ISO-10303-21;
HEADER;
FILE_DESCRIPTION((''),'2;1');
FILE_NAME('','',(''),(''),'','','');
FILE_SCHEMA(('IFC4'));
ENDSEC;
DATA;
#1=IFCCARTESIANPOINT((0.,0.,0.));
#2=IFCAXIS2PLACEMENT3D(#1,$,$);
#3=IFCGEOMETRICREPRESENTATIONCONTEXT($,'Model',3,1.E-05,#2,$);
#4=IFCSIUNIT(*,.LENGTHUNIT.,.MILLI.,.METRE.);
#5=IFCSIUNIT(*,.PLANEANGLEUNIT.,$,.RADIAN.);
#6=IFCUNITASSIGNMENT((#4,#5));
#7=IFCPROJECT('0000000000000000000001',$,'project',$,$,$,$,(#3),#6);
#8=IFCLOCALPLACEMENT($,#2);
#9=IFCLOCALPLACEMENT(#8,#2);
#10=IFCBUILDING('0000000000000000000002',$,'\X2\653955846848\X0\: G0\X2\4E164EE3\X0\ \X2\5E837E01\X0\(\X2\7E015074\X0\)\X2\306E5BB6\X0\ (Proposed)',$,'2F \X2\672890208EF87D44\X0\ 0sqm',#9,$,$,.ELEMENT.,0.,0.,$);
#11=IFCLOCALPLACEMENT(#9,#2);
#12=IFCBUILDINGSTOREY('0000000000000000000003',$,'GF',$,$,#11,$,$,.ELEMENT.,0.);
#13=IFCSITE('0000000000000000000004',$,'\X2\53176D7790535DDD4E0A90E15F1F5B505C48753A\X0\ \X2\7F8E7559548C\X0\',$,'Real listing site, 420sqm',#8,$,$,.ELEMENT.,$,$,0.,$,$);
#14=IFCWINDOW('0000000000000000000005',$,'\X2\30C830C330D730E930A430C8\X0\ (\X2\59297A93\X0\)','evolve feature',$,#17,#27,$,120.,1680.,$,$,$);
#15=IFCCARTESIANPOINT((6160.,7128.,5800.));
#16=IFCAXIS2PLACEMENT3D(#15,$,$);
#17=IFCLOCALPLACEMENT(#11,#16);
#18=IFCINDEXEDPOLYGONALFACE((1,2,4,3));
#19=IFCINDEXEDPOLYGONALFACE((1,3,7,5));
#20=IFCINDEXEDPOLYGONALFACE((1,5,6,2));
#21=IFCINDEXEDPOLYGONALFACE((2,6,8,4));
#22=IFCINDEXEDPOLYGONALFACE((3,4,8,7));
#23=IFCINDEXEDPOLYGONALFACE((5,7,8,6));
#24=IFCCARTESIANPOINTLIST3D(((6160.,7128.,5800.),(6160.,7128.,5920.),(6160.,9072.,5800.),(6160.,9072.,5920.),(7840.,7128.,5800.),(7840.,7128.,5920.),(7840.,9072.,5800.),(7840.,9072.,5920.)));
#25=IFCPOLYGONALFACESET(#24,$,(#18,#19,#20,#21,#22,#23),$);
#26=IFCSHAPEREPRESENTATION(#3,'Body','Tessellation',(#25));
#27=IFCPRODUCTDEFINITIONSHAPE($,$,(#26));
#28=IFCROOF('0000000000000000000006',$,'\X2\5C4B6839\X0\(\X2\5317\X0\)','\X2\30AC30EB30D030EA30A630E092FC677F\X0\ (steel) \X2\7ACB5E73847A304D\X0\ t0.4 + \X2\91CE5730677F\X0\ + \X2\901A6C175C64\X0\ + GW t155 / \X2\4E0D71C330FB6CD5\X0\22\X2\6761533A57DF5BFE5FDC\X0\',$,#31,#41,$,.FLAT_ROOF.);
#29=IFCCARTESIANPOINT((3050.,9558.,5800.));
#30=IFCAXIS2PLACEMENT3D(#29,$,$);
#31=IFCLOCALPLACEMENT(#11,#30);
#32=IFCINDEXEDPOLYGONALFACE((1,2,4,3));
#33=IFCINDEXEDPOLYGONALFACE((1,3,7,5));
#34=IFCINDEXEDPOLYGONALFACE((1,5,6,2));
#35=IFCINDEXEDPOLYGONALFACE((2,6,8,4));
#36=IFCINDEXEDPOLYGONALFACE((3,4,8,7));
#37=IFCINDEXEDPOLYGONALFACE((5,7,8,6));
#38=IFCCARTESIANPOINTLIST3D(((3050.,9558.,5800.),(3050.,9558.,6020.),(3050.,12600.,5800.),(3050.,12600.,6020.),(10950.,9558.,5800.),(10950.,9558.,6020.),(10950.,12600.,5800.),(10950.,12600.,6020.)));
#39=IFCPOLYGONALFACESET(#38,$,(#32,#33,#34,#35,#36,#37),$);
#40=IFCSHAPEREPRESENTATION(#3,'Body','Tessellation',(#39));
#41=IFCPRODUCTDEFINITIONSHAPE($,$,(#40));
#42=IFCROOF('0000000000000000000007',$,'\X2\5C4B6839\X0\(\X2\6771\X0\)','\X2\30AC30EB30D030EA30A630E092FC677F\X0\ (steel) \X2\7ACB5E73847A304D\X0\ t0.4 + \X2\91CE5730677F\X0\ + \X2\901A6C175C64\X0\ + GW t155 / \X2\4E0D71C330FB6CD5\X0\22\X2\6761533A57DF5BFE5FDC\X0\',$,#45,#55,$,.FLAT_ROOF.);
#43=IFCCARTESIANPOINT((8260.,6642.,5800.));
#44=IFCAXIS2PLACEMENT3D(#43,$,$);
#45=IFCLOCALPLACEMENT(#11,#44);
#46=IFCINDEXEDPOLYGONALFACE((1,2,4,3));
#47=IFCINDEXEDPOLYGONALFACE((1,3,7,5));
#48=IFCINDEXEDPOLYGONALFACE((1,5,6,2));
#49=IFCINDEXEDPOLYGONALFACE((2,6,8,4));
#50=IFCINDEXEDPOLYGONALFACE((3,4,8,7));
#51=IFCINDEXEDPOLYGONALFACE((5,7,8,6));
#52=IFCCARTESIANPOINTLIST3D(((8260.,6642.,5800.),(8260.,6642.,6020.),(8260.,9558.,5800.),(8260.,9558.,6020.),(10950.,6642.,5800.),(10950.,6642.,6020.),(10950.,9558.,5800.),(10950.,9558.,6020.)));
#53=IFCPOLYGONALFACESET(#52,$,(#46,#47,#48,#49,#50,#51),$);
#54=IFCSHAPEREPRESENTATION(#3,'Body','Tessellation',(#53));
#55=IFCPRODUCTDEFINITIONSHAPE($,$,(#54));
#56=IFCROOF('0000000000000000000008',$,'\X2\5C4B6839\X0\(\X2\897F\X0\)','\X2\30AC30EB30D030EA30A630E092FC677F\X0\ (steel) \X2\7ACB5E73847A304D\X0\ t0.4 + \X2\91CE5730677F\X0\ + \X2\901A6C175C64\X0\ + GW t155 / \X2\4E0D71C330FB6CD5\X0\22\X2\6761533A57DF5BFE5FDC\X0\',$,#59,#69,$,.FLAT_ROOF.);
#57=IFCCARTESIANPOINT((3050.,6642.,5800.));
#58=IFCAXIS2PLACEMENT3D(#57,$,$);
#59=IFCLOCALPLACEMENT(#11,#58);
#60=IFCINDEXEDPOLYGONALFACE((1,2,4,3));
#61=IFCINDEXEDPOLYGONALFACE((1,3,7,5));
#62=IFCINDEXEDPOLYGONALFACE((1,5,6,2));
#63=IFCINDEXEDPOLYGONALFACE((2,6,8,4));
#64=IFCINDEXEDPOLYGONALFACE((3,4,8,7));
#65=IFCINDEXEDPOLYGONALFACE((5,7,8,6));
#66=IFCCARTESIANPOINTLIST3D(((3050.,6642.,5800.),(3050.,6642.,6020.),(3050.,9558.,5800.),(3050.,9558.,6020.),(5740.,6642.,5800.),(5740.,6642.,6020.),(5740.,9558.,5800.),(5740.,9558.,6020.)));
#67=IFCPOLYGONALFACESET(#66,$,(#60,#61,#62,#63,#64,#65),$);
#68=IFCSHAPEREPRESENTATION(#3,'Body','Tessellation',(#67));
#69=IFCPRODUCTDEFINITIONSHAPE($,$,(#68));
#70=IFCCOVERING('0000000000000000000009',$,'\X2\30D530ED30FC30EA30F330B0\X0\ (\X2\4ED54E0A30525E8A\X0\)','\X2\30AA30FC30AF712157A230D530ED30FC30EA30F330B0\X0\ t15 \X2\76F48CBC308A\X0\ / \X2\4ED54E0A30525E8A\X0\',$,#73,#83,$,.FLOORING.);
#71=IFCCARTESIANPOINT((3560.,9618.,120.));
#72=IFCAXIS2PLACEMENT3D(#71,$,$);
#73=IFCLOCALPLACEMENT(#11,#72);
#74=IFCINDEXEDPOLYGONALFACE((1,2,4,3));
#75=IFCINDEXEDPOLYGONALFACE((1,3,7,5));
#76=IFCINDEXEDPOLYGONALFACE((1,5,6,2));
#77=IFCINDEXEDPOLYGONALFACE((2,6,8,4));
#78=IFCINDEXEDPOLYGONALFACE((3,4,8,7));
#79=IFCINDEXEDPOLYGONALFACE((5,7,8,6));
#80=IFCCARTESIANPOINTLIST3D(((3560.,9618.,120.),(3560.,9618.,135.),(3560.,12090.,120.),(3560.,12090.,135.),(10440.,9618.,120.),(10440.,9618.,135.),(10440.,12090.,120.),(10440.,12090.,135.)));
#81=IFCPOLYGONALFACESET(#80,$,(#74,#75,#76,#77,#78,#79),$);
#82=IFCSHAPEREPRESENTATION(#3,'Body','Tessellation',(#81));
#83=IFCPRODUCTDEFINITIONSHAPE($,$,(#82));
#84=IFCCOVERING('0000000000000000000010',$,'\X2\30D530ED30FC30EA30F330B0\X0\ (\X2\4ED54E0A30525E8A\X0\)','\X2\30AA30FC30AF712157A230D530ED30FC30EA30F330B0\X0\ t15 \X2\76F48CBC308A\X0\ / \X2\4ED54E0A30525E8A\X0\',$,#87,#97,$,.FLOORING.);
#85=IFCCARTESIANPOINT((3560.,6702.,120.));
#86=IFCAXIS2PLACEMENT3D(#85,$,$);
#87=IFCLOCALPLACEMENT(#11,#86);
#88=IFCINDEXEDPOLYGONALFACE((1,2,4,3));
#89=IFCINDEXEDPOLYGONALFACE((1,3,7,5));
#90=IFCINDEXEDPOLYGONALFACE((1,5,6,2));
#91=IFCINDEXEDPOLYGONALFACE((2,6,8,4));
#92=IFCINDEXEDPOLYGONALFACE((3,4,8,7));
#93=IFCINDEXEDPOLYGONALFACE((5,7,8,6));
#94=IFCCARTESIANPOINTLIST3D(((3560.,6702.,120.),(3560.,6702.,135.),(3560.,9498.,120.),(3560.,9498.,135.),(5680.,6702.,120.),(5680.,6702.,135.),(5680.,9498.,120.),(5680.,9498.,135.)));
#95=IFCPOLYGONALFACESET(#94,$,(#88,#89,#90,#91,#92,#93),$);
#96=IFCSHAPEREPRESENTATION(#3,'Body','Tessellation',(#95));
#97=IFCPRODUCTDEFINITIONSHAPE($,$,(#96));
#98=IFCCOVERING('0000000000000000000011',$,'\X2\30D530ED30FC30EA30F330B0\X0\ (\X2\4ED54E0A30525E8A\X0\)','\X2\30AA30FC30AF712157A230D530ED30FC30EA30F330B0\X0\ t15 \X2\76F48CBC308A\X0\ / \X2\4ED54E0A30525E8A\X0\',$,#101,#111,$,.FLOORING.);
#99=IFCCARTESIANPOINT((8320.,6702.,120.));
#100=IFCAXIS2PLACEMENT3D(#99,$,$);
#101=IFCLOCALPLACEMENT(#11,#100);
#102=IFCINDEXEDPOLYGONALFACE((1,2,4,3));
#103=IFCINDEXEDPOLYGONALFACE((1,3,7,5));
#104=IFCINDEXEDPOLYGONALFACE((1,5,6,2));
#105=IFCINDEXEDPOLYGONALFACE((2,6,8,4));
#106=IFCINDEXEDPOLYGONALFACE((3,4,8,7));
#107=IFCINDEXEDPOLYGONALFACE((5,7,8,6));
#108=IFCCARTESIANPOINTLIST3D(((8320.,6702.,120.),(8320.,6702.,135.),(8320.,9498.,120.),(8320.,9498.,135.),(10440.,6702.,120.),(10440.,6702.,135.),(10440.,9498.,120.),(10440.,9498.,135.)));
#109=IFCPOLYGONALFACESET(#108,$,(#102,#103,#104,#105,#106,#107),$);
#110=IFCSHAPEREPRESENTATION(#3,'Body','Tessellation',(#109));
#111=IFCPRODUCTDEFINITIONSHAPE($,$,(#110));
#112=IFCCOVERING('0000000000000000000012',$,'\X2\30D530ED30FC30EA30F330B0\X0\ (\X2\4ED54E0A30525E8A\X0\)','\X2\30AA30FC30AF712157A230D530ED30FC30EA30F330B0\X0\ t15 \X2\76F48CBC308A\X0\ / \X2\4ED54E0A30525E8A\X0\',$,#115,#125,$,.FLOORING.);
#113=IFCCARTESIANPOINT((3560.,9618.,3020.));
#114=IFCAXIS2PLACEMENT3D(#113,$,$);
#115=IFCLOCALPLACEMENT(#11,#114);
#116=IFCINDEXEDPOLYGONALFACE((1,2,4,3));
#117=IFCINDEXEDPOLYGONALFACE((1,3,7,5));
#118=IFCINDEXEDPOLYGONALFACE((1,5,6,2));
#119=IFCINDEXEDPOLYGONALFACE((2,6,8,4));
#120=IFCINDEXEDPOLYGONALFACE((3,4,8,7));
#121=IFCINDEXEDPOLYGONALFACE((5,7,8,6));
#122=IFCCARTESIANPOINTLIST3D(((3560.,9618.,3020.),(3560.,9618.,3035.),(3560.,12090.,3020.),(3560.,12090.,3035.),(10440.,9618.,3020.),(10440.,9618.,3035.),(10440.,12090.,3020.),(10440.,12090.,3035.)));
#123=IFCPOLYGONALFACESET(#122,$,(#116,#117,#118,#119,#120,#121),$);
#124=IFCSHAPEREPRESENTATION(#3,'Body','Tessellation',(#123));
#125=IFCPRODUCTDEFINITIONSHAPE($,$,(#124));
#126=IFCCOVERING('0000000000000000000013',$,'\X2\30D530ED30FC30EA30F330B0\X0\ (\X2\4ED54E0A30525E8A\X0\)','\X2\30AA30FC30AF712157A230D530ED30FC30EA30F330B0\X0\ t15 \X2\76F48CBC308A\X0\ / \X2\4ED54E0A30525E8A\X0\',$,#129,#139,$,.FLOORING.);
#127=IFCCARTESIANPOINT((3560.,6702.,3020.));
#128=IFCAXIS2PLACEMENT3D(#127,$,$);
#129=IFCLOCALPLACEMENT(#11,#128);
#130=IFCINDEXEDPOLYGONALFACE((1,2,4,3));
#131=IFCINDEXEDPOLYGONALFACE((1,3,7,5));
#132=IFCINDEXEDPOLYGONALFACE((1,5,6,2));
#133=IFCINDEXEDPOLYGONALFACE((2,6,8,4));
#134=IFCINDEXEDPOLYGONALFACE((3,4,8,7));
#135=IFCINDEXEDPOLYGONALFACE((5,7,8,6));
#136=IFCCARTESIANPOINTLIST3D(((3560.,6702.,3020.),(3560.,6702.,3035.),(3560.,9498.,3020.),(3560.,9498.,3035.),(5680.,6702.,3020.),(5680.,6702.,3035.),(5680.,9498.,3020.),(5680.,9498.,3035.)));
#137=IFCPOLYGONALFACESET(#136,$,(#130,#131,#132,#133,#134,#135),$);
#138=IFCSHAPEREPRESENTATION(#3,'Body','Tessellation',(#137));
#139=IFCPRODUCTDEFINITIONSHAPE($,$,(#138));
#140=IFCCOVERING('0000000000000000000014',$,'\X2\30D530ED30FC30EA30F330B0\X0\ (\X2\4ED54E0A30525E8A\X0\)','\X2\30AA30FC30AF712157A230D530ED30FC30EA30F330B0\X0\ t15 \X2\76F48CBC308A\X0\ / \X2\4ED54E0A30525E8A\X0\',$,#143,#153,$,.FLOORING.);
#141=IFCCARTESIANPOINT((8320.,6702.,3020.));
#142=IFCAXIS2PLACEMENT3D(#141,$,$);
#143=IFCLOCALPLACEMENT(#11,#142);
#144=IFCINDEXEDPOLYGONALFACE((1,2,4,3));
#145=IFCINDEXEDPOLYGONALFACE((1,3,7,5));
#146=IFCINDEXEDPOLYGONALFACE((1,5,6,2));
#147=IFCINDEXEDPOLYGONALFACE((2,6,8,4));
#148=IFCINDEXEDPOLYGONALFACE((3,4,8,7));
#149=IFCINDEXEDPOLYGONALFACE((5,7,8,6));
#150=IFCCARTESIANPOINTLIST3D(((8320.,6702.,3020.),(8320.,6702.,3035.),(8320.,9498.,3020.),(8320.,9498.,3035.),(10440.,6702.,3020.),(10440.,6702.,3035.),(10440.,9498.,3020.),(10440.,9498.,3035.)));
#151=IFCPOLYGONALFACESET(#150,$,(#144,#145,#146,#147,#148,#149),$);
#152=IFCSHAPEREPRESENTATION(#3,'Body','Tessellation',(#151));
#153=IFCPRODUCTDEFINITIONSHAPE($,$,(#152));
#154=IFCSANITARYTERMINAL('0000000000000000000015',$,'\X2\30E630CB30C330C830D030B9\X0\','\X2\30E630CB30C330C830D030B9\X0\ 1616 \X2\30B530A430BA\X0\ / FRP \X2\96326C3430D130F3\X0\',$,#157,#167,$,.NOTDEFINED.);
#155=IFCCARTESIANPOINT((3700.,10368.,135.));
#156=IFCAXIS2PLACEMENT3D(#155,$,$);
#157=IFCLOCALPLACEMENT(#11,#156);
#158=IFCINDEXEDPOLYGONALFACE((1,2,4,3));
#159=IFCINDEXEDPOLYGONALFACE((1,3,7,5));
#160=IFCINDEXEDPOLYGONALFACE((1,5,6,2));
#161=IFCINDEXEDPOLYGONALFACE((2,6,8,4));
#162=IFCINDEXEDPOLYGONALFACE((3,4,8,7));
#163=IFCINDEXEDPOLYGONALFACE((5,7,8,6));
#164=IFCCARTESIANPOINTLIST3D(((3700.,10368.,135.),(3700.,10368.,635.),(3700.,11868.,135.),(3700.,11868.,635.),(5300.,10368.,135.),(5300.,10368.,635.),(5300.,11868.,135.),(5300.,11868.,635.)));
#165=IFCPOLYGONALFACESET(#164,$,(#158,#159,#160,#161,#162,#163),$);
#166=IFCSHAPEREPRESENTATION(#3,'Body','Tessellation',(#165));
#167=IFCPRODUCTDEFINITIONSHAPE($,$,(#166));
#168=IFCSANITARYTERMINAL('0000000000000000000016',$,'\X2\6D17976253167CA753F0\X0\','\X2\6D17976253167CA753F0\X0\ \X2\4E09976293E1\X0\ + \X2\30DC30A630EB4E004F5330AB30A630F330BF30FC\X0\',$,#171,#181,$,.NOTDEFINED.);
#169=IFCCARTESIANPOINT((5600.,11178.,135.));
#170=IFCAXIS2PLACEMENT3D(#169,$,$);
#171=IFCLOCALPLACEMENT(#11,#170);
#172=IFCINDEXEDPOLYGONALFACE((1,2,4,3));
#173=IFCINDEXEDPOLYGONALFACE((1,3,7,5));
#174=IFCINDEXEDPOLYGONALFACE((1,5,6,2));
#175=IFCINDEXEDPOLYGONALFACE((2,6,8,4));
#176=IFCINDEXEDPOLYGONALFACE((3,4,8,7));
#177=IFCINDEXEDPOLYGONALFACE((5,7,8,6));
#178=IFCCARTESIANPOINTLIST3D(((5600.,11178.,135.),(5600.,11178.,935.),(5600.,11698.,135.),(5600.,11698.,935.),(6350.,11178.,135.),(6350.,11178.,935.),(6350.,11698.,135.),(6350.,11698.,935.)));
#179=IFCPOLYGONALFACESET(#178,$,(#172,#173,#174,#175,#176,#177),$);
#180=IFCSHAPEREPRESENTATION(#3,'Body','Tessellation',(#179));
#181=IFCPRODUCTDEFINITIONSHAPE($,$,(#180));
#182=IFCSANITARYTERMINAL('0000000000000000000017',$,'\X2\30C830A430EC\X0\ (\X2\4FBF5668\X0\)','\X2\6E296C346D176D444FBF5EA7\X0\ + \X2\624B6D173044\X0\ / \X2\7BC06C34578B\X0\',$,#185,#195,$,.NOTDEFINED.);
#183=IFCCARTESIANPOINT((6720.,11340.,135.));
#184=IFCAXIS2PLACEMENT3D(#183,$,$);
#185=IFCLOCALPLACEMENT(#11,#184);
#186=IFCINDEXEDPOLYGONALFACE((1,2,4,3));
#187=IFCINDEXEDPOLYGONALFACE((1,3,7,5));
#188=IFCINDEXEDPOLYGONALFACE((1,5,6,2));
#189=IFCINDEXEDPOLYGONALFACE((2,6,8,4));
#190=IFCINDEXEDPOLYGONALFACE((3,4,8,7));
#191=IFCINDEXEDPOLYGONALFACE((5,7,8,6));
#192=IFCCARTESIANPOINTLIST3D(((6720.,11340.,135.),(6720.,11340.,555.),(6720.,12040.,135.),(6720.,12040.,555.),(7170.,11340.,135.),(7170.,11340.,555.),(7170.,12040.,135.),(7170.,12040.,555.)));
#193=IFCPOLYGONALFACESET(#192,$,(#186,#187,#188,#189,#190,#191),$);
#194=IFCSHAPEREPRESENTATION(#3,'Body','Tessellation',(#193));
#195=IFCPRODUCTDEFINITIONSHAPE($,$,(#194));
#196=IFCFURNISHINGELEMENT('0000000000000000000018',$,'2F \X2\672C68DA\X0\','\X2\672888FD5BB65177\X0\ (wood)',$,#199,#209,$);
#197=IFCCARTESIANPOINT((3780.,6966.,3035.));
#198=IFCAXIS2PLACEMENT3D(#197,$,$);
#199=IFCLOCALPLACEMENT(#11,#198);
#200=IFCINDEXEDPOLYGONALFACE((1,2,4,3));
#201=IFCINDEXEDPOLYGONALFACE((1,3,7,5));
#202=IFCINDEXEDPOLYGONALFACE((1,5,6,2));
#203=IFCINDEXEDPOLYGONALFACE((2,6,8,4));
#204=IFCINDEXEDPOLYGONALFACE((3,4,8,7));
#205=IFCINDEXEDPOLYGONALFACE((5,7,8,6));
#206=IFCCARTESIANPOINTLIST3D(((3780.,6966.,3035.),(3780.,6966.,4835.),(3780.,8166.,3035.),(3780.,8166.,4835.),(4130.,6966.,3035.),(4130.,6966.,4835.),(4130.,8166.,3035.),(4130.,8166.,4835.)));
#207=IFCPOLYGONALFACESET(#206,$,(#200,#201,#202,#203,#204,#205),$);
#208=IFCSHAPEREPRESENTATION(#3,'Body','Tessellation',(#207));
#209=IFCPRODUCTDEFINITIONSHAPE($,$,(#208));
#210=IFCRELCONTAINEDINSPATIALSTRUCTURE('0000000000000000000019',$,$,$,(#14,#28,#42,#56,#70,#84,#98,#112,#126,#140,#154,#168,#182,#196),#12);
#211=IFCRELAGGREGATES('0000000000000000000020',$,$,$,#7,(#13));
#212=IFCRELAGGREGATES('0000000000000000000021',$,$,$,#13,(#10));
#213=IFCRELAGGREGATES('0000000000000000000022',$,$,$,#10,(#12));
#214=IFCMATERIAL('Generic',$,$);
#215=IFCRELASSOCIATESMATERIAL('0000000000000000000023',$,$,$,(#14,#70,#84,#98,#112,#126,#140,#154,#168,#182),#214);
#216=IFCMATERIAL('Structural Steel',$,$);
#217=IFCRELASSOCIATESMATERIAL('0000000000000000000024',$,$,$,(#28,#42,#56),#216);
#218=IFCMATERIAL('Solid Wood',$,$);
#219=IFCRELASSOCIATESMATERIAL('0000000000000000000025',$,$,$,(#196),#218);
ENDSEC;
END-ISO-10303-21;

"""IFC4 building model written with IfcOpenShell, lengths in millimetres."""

from ifc_helpers import new_model, si_unit, frame, frame_2d, origin, place, context, project, spatial, rectangle, extrude, material, element, save


model = new_model("IFC4")

# Units and contexts
model_context = context("Model", 3, precision=1e-05, world=origin())
ifc_project = project(units=[si_unit("LENGTHUNIT", "METRE", prefix="MILLI"), si_unit("PLANEANGLEUNIT", "RADIAN")], contexts=[model_context])

# Site, building, storey
site_placement = place(None, origin())
site = spatial("IfcSite", under=ifc_project, at=site_placement, Name="北海道川上郡弟子屈町 美留和", ObjectType="Real listing site, 420sqm", CompositionType="ELEMENT", RefElevation=0.0)
building_placement = place(site_placement, origin())
building = spatial("IfcBuilding", under=site, at=building_placement, Name="改善案: G0世代 広縁(縁側)の家 (Proposed)", ObjectType="2F 木造軸組 0sqm", CompositionType="ELEMENT", ElevationOfRefHeight=0.0, ElevationOfTerrain=0.0)
storey_placement = place(building_placement, origin())
storey = spatial("IfcBuildingStorey", under=building, at=storey_placement, Name="GF", CompositionType="ELEMENT", Elevation=0.0)

# Shared definitions
ifc_material_1 = material(Name="Solid Wood")

# Window
ifc_material_2 = material(Name="Generic")
window_1_placement = place(storey_placement, frame((6160.0, 7128.0, 5800.0)))
element("IfcWindow", 1, at=window_1_placement, inside=storey, material=ifc_material_2, Name="トップライト (天窓)", Description="evolve feature", OverallHeight=120.0, OverallWidth=1680.0, context=model_context, shape_type="SweptSolid", body=[
    extrude(rectangle(XDim=1680.0, YDim=1944.0, at=frame_2d((840.0, 972.0))), frame((6160.0, 7128.0, 5800.0)), (0.0, 0.0, 1.0), 120.0),
])

# Roofs
ifc_material_3 = material(Name="Structural Steel")
roof_1_placement = place(storey_placement, frame((3050.0, 9558.0, 5800.0)))
element("IfcRoof", 2, at=roof_1_placement, inside=storey, material=ifc_material_3, Name="屋根(北)", Description="ガルバリウム鋼板 (steel) 立平葺き t0.4 + 野地板 + 通気層 + GW t155 / 不燃・法22条区域対応", PredefinedType="FLAT_ROOF", context=model_context, shape_type="SweptSolid", body=[
    extrude(rectangle(XDim=7900.0, YDim=3042.0, at=frame_2d((3950.0, 1521.0))), frame((3050.0, 9558.0, 5800.0)), (0.0, 0.0, 1.0), 220.0),
])
roof_2_placement = place(storey_placement, frame((8260.0, 6642.0, 5800.0)))
element("IfcRoof", 3, at=roof_2_placement, inside=storey, material=ifc_material_3, Name="屋根(東)", Description="ガルバリウム鋼板 (steel) 立平葺き t0.4 + 野地板 + 通気層 + GW t155 / 不燃・法22条区域対応", PredefinedType="FLAT_ROOF", context=model_context, shape_type="SweptSolid", body=[
    extrude(rectangle(XDim=2690.0, YDim=2916.0, at=frame_2d((1345.0, 1458.0))), frame((8260.0, 6642.0, 5800.0)), (0.0, 0.0, 1.0), 220.0),
])
roof_3_placement = place(storey_placement, frame((3050.0, 6642.0, 5800.0)))
element("IfcRoof", 4, at=roof_3_placement, inside=storey, material=ifc_material_3, Name="屋根(西)", Description="ガルバリウム鋼板 (steel) 立平葺き t0.4 + 野地板 + 通気層 + GW t155 / 不燃・法22条区域対応", PredefinedType="FLAT_ROOF", context=model_context, shape_type="SweptSolid", body=[
    extrude(rectangle(XDim=2690.0, YDim=2916.0, at=frame_2d((1345.0, 1458.0))), frame((3050.0, 6642.0, 5800.0)), (0.0, 0.0, 1.0), 220.0),
])

# Coverings
covering_1_placement = place(storey_placement, frame((3560.0, 9618.0, 120.0)))
element("IfcCovering", 5, at=covering_1_placement, inside=storey, material=ifc_material_2, Name="フローリング (仕上げ床)", Description="オーク無垢フローリング t15 直貼り / 仕上げ床", PredefinedType="FLOORING", context=model_context, shape_type="SweptSolid", body=[
    extrude(rectangle(XDim=6880.0, YDim=2472.0, at=frame_2d((3440.0, 1236.0))), frame((3560.0, 9618.0, 120.0)), (0.0, 0.0, 1.0), 15.0),
])
covering_2_placement = place(storey_placement, frame((3560.0, 6702.0, 120.0)))
element("IfcCovering", 6, at=covering_2_placement, inside=storey, material=ifc_material_2, Name="フローリング (仕上げ床)", Description="オーク無垢フローリング t15 直貼り / 仕上げ床", PredefinedType="FLOORING", context=model_context, shape_type="SweptSolid", body=[
    extrude(rectangle(XDim=2120.0, YDim=2796.0, at=frame_2d((1060.0, 1398.0))), frame((3560.0, 6702.0, 120.0)), (0.0, 0.0, 1.0), 15.0),
])
covering_3_placement = place(storey_placement, frame((8320.0, 6702.0, 120.0)))
element("IfcCovering", 7, at=covering_3_placement, inside=storey, material=ifc_material_2, Name="フローリング (仕上げ床)", Description="オーク無垢フローリング t15 直貼り / 仕上げ床", PredefinedType="FLOORING", context=model_context, shape_type="SweptSolid", body=[
    extrude(rectangle(XDim=2120.0, YDim=2796.0, at=frame_2d((1060.0, 1398.0))), frame((8320.0, 6702.0, 120.0)), (0.0, 0.0, 1.0), 15.0),
])
covering_4_placement = place(storey_placement, frame((3560.0, 9618.0, 3020.0)))
element("IfcCovering", 8, at=covering_4_placement, inside=storey, material=ifc_material_2, Name="フローリング (仕上げ床)", Description="オーク無垢フローリング t15 直貼り / 仕上げ床", PredefinedType="FLOORING", context=model_context, shape_type="SweptSolid", body=[
    extrude(rectangle(XDim=6880.0, YDim=2472.0, at=frame_2d((3440.0, 1236.0))), frame((3560.0, 9618.0, 3020.0)), (0.0, 0.0, 1.0), 15.0),
])
covering_5_placement = place(storey_placement, frame((3560.0, 6702.0, 3020.0)))
element("IfcCovering", 9, at=covering_5_placement, inside=storey, material=ifc_material_2, Name="フローリング (仕上げ床)", Description="オーク無垢フローリング t15 直貼り / 仕上げ床", PredefinedType="FLOORING", context=model_context, shape_type="SweptSolid", body=[
    extrude(rectangle(XDim=2120.0, YDim=2796.0, at=frame_2d((1060.0, 1398.0))), frame((3560.0, 6702.0, 3020.0)), (0.0, 0.0, 1.0), 15.0),
])
covering_6_placement = place(storey_placement, frame((8320.0, 6702.0, 3020.0)))
element("IfcCovering", 10, at=covering_6_placement, inside=storey, material=ifc_material_2, Name="フローリング (仕上げ床)", Description="オーク無垢フローリング t15 直貼り / 仕上げ床", PredefinedType="FLOORING", context=model_context, shape_type="SweptSolid", body=[
    extrude(rectangle(XDim=2120.0, YDim=2796.0, at=frame_2d((1060.0, 1398.0))), frame((8320.0, 6702.0, 3020.0)), (0.0, 0.0, 1.0), 15.0),
])

# Sanitary terminals
sanitary_terminal_1_placement = place(storey_placement, frame((3700.0, 10368.0, 135.0)))
element("IfcSanitaryTerminal", 11, at=sanitary_terminal_1_placement, inside=storey, material=ifc_material_2, Name="ユニットバス", Description="ユニットバス 1616 サイズ / FRP 防水パン", PredefinedType="NOTDEFINED", context=model_context, shape_type="SweptSolid", body=[
    extrude(rectangle(XDim=1600.0, YDim=1500.0, at=frame_2d((800.0, 750.0))), frame((3700.0, 10368.0, 135.0)), (0.0, 0.0, 1.0), 500.0),
])
sanitary_terminal_2_placement = place(storey_placement, frame((5600.0, 11178.0, 135.0)))
element("IfcSanitaryTerminal", 12, at=sanitary_terminal_2_placement, inside=storey, material=ifc_material_2, Name="洗面化粧台", Description="洗面化粧台 三面鏡 + ボウル一体カウンター", PredefinedType="NOTDEFINED", context=model_context, shape_type="SweptSolid", body=[
    extrude(rectangle(XDim=750.0, YDim=520.0, at=frame_2d((375.0, 260.0))), frame((5600.0, 11178.0, 135.0)), (0.0, 0.0, 1.0), 800.0),
])
sanitary_terminal_3_placement = place(storey_placement, frame((6720.0, 11340.0, 135.0)))
element("IfcSanitaryTerminal", 13, at=sanitary_terminal_3_placement, inside=storey, material=ifc_material_2, Name="トイレ (便器)", Description="温水洗浄便座 + 手洗い / 節水型", PredefinedType="NOTDEFINED", context=model_context, shape_type="SweptSolid", body=[
    extrude(rectangle(XDim=450.0, YDim=700.0, at=frame_2d((225.0, 350.0))), frame((6720.0, 11340.0, 135.0)), (0.0, 0.0, 1.0), 420.0),
])

# Furnishing element
furnishing_placement = place(storey_placement, frame((3780.0, 6966.0, 3035.0)))
element("IfcFurnishingElement", 14, at=furnishing_placement, inside=storey, material=ifc_material_1, Name="2F 本棚", Description="木製家具 (wood)", context=model_context, shape_type="SweptSolid", body=[
    extrude(rectangle(XDim=350.0, YDim=1200.0, at=frame_2d((175.0, 600.0))), frame((3780.0, 6966.0, 3035.0)), (0.0, 0.0, 1.0), 1800.0),
])

save(model, "model.ifc")
